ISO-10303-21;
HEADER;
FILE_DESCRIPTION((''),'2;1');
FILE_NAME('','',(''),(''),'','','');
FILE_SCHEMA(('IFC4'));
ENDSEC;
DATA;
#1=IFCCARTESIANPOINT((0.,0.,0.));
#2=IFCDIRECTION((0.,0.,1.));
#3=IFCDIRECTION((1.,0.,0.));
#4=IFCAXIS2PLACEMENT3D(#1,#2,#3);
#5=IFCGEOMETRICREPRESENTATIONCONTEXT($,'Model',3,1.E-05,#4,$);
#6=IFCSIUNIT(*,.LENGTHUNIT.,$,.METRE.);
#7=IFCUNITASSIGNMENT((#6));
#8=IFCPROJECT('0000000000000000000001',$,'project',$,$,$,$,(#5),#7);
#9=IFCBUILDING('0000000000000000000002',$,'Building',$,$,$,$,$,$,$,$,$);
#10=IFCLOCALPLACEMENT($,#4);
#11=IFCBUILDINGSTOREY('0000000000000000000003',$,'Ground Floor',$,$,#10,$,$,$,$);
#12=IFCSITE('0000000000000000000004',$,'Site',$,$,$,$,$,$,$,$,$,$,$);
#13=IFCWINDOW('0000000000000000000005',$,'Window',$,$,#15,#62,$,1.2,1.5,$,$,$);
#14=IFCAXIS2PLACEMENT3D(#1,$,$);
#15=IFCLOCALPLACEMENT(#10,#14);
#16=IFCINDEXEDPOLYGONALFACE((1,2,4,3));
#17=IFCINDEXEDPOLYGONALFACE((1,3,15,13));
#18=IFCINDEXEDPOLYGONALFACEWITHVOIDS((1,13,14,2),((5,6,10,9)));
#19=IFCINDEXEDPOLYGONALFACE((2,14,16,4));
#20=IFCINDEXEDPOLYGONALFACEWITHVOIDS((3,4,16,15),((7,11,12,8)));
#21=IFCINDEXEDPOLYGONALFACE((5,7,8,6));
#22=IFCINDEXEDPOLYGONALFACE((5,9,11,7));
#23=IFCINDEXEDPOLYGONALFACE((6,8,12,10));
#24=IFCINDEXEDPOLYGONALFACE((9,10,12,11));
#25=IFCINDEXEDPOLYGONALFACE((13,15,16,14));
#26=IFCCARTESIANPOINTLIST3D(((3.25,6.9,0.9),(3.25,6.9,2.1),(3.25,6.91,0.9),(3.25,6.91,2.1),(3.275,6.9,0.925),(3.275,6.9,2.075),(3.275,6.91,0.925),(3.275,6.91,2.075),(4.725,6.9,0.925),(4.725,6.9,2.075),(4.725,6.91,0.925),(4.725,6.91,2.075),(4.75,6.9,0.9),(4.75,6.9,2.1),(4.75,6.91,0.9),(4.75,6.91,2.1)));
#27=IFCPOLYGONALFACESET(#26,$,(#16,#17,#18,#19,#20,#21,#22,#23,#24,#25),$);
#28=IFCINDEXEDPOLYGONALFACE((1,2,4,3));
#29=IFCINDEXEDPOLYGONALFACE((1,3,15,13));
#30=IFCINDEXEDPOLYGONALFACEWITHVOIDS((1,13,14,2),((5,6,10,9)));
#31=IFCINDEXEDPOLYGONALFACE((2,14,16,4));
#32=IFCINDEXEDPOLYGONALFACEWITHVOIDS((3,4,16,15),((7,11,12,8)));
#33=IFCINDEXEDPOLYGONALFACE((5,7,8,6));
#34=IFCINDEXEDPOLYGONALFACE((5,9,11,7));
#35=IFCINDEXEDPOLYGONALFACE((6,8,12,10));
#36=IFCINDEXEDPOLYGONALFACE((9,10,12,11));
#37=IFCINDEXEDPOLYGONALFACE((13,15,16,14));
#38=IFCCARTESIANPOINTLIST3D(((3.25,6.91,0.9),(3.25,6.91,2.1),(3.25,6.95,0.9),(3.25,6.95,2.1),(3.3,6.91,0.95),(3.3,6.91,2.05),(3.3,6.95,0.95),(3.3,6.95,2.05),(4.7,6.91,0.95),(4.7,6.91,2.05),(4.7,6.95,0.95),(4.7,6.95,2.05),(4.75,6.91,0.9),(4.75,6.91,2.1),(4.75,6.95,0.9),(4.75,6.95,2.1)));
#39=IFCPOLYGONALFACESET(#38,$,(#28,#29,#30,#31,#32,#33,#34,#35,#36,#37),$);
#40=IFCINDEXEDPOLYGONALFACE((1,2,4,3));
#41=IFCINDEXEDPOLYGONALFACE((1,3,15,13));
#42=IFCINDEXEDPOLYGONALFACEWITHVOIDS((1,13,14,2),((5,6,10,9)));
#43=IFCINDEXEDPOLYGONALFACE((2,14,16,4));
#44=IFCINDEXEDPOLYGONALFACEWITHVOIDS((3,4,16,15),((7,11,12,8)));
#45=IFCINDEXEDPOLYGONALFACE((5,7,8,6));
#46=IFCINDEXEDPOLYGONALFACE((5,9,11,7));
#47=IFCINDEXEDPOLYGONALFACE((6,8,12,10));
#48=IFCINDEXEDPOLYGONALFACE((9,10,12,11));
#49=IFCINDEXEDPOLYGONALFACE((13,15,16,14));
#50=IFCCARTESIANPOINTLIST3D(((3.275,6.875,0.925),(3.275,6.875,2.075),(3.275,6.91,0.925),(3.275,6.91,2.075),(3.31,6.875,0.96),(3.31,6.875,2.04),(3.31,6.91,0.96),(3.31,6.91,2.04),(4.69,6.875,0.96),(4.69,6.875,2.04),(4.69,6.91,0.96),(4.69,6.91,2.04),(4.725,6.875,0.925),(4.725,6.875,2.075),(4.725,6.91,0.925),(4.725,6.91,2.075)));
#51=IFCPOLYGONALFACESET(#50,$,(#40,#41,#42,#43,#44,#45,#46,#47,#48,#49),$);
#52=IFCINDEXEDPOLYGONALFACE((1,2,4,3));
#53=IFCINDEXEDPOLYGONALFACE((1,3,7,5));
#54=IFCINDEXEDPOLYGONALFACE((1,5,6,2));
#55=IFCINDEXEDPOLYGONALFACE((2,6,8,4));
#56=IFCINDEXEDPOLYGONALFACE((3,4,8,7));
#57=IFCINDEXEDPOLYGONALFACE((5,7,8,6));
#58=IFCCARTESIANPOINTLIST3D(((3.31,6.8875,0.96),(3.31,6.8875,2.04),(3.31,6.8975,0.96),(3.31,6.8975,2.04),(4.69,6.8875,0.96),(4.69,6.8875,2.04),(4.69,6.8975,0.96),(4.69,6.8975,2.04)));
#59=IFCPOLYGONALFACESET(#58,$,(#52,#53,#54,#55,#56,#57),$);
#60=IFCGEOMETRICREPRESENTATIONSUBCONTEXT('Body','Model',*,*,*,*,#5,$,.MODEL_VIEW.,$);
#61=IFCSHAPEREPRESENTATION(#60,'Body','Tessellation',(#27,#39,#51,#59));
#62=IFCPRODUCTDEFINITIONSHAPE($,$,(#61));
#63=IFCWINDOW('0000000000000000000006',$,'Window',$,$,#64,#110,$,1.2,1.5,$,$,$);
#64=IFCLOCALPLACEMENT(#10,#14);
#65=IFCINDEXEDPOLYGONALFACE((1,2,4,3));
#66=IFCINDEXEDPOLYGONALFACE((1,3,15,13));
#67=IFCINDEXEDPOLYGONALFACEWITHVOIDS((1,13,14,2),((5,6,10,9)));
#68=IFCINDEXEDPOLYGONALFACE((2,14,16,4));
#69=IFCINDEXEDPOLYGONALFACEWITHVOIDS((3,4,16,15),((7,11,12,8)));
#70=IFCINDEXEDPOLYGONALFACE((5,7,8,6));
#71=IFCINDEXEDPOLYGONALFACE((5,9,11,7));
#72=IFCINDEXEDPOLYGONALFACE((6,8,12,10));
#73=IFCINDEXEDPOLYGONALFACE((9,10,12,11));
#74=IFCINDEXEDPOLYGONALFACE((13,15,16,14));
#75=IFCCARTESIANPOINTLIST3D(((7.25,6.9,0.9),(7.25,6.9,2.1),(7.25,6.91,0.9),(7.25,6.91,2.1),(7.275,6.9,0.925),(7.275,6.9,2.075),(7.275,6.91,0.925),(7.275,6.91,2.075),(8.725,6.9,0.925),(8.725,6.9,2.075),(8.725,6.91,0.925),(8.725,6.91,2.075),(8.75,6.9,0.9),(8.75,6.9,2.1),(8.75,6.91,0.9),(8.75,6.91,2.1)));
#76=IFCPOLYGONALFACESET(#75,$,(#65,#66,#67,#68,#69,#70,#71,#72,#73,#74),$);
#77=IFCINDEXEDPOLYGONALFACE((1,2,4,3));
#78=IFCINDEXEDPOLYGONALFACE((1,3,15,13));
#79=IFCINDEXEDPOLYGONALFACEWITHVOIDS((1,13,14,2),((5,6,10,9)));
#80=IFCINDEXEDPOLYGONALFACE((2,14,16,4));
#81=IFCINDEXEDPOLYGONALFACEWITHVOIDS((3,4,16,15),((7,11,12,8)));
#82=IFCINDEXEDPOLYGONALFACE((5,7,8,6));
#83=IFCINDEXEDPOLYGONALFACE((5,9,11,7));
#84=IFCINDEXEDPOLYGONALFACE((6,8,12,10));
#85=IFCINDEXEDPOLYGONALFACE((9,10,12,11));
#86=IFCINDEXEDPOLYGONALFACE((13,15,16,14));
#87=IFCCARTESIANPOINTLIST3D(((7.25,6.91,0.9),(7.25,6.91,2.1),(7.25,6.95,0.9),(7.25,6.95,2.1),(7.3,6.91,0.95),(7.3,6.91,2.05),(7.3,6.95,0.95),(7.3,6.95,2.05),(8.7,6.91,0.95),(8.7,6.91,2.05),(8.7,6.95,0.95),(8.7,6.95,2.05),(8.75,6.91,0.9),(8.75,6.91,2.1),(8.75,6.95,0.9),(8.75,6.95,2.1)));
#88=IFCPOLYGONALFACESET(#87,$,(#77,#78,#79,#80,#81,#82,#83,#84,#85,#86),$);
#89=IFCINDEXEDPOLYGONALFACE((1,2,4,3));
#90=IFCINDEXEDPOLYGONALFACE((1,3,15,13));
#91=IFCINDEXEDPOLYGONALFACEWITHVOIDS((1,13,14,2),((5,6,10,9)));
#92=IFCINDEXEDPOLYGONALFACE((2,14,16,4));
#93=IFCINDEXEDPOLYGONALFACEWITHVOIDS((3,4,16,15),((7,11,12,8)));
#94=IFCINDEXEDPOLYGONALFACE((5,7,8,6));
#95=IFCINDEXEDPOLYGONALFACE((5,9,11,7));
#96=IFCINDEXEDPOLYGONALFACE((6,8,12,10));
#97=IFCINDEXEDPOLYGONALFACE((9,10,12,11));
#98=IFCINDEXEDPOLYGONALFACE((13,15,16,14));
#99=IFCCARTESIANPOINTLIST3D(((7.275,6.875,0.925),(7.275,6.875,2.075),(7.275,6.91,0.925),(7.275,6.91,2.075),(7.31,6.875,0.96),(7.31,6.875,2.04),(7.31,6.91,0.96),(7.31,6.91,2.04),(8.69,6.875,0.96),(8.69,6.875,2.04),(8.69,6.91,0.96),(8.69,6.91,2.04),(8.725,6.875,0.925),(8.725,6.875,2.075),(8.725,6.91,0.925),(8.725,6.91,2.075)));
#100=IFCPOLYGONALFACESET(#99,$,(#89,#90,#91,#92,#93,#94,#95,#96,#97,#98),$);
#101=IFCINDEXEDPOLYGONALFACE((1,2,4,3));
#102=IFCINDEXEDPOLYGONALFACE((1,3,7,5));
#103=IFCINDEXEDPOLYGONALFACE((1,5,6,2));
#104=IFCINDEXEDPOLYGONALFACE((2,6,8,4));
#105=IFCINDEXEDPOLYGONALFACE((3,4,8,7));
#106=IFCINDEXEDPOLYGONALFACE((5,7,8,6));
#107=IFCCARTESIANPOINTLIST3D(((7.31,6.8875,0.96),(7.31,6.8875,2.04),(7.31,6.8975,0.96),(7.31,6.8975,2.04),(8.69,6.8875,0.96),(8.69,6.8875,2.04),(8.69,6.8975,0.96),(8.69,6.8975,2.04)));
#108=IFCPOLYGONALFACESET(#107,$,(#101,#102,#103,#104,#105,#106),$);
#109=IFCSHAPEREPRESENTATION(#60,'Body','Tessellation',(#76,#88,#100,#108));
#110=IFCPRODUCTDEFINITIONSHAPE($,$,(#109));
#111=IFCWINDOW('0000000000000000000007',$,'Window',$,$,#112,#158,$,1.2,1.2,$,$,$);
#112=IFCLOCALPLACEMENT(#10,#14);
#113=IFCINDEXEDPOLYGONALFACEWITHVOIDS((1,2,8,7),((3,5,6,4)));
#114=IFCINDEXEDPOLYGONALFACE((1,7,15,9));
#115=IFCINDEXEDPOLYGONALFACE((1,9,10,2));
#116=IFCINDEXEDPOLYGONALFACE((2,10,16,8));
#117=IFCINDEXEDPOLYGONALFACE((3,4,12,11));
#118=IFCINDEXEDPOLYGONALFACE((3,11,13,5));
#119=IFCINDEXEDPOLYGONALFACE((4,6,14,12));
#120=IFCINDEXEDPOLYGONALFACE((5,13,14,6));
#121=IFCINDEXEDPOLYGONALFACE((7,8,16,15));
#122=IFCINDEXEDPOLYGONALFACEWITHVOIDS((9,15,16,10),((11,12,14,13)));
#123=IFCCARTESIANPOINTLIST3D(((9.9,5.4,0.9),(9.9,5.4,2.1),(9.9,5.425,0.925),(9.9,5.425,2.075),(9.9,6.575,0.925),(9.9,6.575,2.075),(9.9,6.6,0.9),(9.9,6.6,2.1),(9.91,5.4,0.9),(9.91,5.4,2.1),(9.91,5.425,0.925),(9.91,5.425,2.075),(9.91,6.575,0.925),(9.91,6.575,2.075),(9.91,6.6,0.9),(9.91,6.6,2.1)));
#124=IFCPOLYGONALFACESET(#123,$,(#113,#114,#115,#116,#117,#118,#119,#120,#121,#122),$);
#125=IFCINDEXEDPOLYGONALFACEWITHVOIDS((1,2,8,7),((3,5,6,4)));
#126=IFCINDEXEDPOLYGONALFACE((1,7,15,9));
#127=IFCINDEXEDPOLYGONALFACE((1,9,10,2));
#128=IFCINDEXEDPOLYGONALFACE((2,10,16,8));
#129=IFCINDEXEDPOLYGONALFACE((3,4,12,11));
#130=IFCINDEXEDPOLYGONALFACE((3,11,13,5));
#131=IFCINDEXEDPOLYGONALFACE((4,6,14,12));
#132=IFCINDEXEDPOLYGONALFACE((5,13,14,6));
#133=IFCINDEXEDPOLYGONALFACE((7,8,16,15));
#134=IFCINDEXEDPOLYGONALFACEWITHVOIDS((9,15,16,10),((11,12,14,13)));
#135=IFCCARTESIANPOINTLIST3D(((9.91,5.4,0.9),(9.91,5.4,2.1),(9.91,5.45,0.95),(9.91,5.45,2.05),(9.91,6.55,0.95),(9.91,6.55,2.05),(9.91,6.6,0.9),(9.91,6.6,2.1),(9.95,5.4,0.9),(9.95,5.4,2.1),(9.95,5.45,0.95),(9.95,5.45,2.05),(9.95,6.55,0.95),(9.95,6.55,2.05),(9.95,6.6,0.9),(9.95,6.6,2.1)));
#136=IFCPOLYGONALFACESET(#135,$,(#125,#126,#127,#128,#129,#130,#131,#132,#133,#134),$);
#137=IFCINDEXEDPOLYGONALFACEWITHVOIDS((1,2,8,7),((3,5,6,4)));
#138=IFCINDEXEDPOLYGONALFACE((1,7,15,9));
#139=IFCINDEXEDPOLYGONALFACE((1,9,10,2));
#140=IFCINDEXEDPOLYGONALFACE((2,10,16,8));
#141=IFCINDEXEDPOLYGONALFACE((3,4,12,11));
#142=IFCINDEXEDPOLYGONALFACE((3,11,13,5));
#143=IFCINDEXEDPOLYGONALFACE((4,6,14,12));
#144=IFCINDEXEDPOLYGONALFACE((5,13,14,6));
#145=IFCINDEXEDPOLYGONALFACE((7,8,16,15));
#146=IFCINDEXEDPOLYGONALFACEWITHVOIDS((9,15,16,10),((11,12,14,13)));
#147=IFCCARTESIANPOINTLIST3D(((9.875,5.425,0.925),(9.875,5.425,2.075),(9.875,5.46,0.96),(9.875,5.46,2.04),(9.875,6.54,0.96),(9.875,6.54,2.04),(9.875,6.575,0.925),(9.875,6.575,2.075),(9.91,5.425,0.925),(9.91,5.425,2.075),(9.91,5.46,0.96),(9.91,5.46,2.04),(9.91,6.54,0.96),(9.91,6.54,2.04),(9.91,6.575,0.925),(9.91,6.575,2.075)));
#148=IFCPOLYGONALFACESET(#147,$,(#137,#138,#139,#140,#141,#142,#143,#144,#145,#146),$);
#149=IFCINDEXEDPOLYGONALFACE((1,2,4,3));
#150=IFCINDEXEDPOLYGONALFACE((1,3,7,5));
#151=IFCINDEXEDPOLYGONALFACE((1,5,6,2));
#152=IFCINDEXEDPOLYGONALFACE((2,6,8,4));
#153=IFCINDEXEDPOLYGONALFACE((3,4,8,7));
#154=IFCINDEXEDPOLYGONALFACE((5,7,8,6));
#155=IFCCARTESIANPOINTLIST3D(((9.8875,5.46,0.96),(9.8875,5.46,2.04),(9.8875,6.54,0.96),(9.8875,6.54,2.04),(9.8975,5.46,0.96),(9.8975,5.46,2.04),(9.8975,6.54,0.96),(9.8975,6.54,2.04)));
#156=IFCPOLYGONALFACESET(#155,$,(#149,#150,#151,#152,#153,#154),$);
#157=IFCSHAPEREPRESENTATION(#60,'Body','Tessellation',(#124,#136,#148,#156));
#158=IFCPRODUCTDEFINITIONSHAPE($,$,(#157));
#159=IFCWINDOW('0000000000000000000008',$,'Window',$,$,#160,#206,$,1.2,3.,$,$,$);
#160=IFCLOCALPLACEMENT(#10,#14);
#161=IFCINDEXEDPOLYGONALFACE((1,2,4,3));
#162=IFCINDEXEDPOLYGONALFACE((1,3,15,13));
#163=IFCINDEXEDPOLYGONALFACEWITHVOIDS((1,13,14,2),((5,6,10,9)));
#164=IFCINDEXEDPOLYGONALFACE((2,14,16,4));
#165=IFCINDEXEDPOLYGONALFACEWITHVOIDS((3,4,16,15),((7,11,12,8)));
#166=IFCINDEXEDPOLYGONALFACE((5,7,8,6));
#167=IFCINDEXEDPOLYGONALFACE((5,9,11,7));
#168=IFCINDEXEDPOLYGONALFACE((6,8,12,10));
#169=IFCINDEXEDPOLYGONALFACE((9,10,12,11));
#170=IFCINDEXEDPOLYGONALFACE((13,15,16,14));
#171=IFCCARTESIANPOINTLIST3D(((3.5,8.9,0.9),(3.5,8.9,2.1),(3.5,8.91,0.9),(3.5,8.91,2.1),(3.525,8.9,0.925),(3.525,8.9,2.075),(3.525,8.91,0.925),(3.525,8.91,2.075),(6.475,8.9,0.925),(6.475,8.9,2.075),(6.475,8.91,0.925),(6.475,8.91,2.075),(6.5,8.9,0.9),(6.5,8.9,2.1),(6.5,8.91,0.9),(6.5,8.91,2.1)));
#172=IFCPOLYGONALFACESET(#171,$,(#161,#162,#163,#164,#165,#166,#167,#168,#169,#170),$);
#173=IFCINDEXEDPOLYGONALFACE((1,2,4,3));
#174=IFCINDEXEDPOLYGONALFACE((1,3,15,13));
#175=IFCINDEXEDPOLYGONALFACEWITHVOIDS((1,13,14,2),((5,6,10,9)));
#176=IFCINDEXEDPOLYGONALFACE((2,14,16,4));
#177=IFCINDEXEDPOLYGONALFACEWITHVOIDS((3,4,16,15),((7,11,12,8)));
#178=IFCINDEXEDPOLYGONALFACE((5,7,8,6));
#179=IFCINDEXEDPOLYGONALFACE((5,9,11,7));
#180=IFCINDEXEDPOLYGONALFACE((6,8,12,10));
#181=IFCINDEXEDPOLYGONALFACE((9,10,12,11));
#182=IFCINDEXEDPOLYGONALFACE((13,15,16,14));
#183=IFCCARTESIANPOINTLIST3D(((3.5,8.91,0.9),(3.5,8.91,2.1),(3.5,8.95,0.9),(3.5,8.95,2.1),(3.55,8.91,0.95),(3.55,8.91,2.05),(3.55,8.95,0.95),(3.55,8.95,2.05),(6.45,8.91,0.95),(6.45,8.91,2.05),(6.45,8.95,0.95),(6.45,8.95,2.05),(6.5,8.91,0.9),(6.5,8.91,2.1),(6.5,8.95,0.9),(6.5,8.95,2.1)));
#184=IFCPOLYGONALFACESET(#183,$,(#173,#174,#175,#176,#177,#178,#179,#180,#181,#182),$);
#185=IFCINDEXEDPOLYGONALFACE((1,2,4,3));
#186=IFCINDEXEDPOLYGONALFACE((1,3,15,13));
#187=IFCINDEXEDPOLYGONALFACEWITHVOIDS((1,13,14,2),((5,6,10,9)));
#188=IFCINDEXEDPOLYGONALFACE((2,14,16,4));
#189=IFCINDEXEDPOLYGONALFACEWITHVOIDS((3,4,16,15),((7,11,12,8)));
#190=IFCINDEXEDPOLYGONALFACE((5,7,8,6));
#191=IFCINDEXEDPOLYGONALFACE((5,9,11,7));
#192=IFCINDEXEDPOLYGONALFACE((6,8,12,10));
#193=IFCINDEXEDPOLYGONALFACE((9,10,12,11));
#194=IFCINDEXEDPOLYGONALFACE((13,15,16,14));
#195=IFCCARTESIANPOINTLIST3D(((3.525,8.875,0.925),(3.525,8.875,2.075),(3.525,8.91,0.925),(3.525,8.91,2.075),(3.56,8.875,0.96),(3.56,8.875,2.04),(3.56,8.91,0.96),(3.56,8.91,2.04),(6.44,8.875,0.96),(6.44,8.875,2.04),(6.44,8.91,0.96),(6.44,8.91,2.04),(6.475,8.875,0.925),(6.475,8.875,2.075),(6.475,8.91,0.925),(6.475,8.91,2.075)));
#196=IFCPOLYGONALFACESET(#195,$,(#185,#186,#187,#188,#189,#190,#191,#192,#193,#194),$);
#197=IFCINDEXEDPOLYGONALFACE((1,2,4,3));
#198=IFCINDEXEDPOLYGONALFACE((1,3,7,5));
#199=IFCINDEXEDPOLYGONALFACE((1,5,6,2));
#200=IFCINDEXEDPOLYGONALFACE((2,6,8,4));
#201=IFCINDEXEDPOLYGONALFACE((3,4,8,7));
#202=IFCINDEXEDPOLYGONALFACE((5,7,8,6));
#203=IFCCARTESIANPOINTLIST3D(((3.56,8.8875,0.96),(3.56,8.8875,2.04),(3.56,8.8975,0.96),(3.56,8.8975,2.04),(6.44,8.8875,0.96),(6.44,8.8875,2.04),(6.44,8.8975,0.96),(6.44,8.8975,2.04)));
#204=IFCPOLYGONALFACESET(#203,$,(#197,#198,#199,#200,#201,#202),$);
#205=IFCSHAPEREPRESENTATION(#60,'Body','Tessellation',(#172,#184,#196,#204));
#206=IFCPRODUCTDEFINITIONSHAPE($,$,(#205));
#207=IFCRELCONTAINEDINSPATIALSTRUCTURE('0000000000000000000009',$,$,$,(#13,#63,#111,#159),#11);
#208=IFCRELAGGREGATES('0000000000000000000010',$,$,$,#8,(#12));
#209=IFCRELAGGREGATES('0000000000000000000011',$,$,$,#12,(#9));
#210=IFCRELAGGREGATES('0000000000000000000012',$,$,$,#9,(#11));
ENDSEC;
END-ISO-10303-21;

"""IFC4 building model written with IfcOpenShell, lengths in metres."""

from ifc_helpers import new_model, si_unit, frame, origin_with_axes, place, context, subcontext, project, spatial, line, indexed_curve, outline, extrude, element, save


model = new_model("IFC4")

# Units and contexts
model_context = context("Model", 3, precision=1e-05, world=origin_with_axes())
body_context = subcontext(model_context, "Body", "Model", "MODEL_VIEW")
ifc_project = project(units=[si_unit("LENGTHUNIT", "METRE")], contexts=[model_context])

# Site, building, storey
site = spatial("IfcSite", under=ifc_project, Name="Site")
building = spatial("IfcBuilding", under=site, Name="Building")
storey_placement = place(None, origin_with_axes())
storey = spatial("IfcBuildingStorey", under=building, at=storey_placement, Name="Ground Floor")

# Windows
for number, where, z_axis, x_axis, name in (
    (1, (4.75, 7.0, 0.9), (0.0, 0.0, 1.0), (-1.0, 0.0, 0.0), "Window"),
    (2, (8.75, 7.0, 0.9), (0.0, 0.0, 1.0), (-1.0, 0.0, 0.0), "Window"),
):
    element("IfcWindow", number, at=place(storey_placement, frame(where, z_axis=z_axis, x_axis=x_axis)), inside=storey, Name=name, OverallHeight=1.2, OverallWidth=1.5, context=body_context, shape_type="SweptSolid", body=[
        extrude(outline(indexed_curve([(0.0, 0.0), (1.5, 0.0), (1.5, 1.2), (0.0, 1.2)], segments=[line(1, 2, 3, 4, 1)]), holes=[indexed_curve([(0.025, 0.025), (1.475, 0.025), (1.475, 1.175), (0.025, 1.175)], segments=[line(1, 2, 3, 4, 1)])]), frame((0.0, 0.09, 0.0), z_axis=(0.0, -1.0, 0.0), x_axis=(1.0, 0.0, 0.0)), (0.0, 0.0, -1.0), 0.01),
        extrude(outline(indexed_curve([(0.0, 0.0), (1.5, 0.0), (1.5, 1.2), (0.0, 1.2)], segments=[line(1, 2, 3, 4, 1)]), holes=[indexed_curve([(0.05, 0.05), (1.45, 0.05), (1.45, 1.15), (0.05, 1.15)], segments=[line(1, 2, 3, 4, 1)])]), frame((0.0, 0.05, 0.0), z_axis=(0.0, -1.0, 0.0), x_axis=(1.0, 0.0, 0.0)), (0.0, 0.0, -1.0), 0.04),
        extrude(outline(indexed_curve([(0.0, 0.0), (1.45, 0.0), (1.45, 1.15), (0.0, 1.15)], segments=[line(1, 2, 3, 4, 1)]), holes=[indexed_curve([(0.035, 0.035), (1.415, 0.035), (1.415, 1.115), (0.035, 1.115)], segments=[line(1, 2, 3, 4, 1)])]), frame((0.025, 0.09, 0.025), z_axis=(0.0, -1.0, 0.0), x_axis=(1.0, 0.0, 0.0)), (0.0, 0.0, -1.0), 0.035),
        extrude(outline(indexed_curve([(0.035, 0.035), (1.415, 0.035), (1.415, 1.115), (0.035, 1.115)], segments=[line(1, 2, 3, 4, 1)])), frame((0.025, 0.1025, 0.025), z_axis=(0.0, -1.0, 0.0), x_axis=(1.0, 0.0, 0.0)), (0.0, 0.0, -1.0), 0.01),
    ])
window_1_placement = place(storey_placement, frame((10.0, 5.4, 0.9), z_axis=(0.0, 0.0, 1.0), x_axis=(0.0, 1.0, 0.0)))
element("IfcWindow", 3, at=window_1_placement, inside=storey, Name="Window", OverallHeight=1.2, OverallWidth=1.2, context=body_context, shape_type="SweptSolid", body=[
    extrude(outline(indexed_curve([(0.0, 0.0), (1.2, 0.0), (1.2, 1.2), (0.0, 1.2)], segments=[line(1, 2, 3, 4, 1)]), holes=[indexed_curve([(0.025, 0.025), (1.175, 0.025), (1.175, 1.175), (0.025, 1.175)], segments=[line(1, 2, 3, 4, 1)])]), frame((0.0, 0.09, 0.0), z_axis=(0.0, -1.0, 0.0), x_axis=(1.0, 0.0, 0.0)), (0.0, 0.0, -1.0), 0.01),
    extrude(outline(indexed_curve([(0.0, 0.0), (1.2, 0.0), (1.2, 1.2), (0.0, 1.2)], segments=[line(1, 2, 3, 4, 1)]), holes=[indexed_curve([(0.05, 0.05), (1.15, 0.05), (1.15, 1.15), (0.05, 1.15)], segments=[line(1, 2, 3, 4, 1)])]), frame((0.0, 0.05, 0.0), z_axis=(0.0, -1.0, 0.0), x_axis=(1.0, 0.0, 0.0)), (0.0, 0.0, -1.0), 0.04),
    extrude(outline(indexed_curve([(0.0, 0.0), (1.15, 0.0), (1.15, 1.15), (0.0, 1.15)], segments=[line(1, 2, 3, 4, 1)]), holes=[indexed_curve([(0.035, 0.035), (1.115, 0.035), (1.115, 1.115), (0.035, 1.115)], segments=[line(1, 2, 3, 4, 1)])]), frame((0.025, 0.09, 0.025), z_axis=(0.0, -1.0, 0.0), x_axis=(1.0, 0.0, 0.0)), (0.0, 0.0, -1.0), 0.035),
    extrude(outline(indexed_curve([(0.035, 0.035), (1.115, 0.035), (1.115, 1.115), (0.035, 1.115)], segments=[line(1, 2, 3, 4, 1)])), frame((0.025, 0.1025, 0.025), z_axis=(0.0, -1.0, 0.0), x_axis=(1.0, 0.0, 0.0)), (0.0, 0.0, -1.0), 0.01),
])
window_2_placement = place(storey_placement, frame((6.5, 9.0, 0.9), z_axis=(0.0, 0.0, 1.0), x_axis=(-1.0, 0.0, 0.0)))
element("IfcWindow", 4, at=window_2_placement, inside=storey, Name="Window", OverallHeight=1.2, OverallWidth=3.0, context=body_context, shape_type="SweptSolid", body=[
    extrude(outline(indexed_curve([(0.0, 0.0), (3.0, 0.0), (3.0, 1.2), (0.0, 1.2)], segments=[line(1, 2, 3, 4, 1)]), holes=[indexed_curve([(0.025, 0.025), (2.975, 0.025), (2.975, 1.175), (0.025, 1.175)], segments=[line(1, 2, 3, 4, 1)])]), frame((0.0, 0.09, 0.0), z_axis=(0.0, -1.0, 0.0), x_axis=(1.0, 0.0, 0.0)), (0.0, 0.0, -1.0), 0.01),
    extrude(outline(indexed_curve([(0.0, 0.0), (3.0, 0.0), (3.0, 1.2), (0.0, 1.2)], segments=[line(1, 2, 3, 4, 1)]), holes=[indexed_curve([(0.05, 0.05), (2.95, 0.05), (2.95, 1.15), (0.05, 1.15)], segments=[line(1, 2, 3, 4, 1)])]), frame((0.0, 0.05, 0.0), z_axis=(0.0, -1.0, 0.0), x_axis=(1.0, 0.0, 0.0)), (0.0, 0.0, -1.0), 0.04),
    extrude(outline(indexed_curve([(0.0, 0.0), (2.95, 0.0), (2.95, 1.15), (0.0, 1.15)], segments=[line(1, 2, 3, 4, 1)]), holes=[indexed_curve([(0.035, 0.035), (2.915, 0.035), (2.915, 1.115), (0.035, 1.115)], segments=[line(1, 2, 3, 4, 1)])]), frame((0.025, 0.09, 0.025), z_axis=(0.0, -1.0, 0.0), x_axis=(1.0, 0.0, 0.0)), (0.0, 0.0, -1.0), 0.035),
    extrude(outline(indexed_curve([(0.035, 0.035), (2.915, 0.035), (2.915, 1.115), (0.035, 1.115)], segments=[line(1, 2, 3, 4, 1)])), frame((0.025, 0.1025, 0.025), z_axis=(0.0, -1.0, 0.0), x_axis=(1.0, 0.0, 0.0)), (0.0, 0.0, -1.0), 0.01),
])

save(model, "model.ifc")
